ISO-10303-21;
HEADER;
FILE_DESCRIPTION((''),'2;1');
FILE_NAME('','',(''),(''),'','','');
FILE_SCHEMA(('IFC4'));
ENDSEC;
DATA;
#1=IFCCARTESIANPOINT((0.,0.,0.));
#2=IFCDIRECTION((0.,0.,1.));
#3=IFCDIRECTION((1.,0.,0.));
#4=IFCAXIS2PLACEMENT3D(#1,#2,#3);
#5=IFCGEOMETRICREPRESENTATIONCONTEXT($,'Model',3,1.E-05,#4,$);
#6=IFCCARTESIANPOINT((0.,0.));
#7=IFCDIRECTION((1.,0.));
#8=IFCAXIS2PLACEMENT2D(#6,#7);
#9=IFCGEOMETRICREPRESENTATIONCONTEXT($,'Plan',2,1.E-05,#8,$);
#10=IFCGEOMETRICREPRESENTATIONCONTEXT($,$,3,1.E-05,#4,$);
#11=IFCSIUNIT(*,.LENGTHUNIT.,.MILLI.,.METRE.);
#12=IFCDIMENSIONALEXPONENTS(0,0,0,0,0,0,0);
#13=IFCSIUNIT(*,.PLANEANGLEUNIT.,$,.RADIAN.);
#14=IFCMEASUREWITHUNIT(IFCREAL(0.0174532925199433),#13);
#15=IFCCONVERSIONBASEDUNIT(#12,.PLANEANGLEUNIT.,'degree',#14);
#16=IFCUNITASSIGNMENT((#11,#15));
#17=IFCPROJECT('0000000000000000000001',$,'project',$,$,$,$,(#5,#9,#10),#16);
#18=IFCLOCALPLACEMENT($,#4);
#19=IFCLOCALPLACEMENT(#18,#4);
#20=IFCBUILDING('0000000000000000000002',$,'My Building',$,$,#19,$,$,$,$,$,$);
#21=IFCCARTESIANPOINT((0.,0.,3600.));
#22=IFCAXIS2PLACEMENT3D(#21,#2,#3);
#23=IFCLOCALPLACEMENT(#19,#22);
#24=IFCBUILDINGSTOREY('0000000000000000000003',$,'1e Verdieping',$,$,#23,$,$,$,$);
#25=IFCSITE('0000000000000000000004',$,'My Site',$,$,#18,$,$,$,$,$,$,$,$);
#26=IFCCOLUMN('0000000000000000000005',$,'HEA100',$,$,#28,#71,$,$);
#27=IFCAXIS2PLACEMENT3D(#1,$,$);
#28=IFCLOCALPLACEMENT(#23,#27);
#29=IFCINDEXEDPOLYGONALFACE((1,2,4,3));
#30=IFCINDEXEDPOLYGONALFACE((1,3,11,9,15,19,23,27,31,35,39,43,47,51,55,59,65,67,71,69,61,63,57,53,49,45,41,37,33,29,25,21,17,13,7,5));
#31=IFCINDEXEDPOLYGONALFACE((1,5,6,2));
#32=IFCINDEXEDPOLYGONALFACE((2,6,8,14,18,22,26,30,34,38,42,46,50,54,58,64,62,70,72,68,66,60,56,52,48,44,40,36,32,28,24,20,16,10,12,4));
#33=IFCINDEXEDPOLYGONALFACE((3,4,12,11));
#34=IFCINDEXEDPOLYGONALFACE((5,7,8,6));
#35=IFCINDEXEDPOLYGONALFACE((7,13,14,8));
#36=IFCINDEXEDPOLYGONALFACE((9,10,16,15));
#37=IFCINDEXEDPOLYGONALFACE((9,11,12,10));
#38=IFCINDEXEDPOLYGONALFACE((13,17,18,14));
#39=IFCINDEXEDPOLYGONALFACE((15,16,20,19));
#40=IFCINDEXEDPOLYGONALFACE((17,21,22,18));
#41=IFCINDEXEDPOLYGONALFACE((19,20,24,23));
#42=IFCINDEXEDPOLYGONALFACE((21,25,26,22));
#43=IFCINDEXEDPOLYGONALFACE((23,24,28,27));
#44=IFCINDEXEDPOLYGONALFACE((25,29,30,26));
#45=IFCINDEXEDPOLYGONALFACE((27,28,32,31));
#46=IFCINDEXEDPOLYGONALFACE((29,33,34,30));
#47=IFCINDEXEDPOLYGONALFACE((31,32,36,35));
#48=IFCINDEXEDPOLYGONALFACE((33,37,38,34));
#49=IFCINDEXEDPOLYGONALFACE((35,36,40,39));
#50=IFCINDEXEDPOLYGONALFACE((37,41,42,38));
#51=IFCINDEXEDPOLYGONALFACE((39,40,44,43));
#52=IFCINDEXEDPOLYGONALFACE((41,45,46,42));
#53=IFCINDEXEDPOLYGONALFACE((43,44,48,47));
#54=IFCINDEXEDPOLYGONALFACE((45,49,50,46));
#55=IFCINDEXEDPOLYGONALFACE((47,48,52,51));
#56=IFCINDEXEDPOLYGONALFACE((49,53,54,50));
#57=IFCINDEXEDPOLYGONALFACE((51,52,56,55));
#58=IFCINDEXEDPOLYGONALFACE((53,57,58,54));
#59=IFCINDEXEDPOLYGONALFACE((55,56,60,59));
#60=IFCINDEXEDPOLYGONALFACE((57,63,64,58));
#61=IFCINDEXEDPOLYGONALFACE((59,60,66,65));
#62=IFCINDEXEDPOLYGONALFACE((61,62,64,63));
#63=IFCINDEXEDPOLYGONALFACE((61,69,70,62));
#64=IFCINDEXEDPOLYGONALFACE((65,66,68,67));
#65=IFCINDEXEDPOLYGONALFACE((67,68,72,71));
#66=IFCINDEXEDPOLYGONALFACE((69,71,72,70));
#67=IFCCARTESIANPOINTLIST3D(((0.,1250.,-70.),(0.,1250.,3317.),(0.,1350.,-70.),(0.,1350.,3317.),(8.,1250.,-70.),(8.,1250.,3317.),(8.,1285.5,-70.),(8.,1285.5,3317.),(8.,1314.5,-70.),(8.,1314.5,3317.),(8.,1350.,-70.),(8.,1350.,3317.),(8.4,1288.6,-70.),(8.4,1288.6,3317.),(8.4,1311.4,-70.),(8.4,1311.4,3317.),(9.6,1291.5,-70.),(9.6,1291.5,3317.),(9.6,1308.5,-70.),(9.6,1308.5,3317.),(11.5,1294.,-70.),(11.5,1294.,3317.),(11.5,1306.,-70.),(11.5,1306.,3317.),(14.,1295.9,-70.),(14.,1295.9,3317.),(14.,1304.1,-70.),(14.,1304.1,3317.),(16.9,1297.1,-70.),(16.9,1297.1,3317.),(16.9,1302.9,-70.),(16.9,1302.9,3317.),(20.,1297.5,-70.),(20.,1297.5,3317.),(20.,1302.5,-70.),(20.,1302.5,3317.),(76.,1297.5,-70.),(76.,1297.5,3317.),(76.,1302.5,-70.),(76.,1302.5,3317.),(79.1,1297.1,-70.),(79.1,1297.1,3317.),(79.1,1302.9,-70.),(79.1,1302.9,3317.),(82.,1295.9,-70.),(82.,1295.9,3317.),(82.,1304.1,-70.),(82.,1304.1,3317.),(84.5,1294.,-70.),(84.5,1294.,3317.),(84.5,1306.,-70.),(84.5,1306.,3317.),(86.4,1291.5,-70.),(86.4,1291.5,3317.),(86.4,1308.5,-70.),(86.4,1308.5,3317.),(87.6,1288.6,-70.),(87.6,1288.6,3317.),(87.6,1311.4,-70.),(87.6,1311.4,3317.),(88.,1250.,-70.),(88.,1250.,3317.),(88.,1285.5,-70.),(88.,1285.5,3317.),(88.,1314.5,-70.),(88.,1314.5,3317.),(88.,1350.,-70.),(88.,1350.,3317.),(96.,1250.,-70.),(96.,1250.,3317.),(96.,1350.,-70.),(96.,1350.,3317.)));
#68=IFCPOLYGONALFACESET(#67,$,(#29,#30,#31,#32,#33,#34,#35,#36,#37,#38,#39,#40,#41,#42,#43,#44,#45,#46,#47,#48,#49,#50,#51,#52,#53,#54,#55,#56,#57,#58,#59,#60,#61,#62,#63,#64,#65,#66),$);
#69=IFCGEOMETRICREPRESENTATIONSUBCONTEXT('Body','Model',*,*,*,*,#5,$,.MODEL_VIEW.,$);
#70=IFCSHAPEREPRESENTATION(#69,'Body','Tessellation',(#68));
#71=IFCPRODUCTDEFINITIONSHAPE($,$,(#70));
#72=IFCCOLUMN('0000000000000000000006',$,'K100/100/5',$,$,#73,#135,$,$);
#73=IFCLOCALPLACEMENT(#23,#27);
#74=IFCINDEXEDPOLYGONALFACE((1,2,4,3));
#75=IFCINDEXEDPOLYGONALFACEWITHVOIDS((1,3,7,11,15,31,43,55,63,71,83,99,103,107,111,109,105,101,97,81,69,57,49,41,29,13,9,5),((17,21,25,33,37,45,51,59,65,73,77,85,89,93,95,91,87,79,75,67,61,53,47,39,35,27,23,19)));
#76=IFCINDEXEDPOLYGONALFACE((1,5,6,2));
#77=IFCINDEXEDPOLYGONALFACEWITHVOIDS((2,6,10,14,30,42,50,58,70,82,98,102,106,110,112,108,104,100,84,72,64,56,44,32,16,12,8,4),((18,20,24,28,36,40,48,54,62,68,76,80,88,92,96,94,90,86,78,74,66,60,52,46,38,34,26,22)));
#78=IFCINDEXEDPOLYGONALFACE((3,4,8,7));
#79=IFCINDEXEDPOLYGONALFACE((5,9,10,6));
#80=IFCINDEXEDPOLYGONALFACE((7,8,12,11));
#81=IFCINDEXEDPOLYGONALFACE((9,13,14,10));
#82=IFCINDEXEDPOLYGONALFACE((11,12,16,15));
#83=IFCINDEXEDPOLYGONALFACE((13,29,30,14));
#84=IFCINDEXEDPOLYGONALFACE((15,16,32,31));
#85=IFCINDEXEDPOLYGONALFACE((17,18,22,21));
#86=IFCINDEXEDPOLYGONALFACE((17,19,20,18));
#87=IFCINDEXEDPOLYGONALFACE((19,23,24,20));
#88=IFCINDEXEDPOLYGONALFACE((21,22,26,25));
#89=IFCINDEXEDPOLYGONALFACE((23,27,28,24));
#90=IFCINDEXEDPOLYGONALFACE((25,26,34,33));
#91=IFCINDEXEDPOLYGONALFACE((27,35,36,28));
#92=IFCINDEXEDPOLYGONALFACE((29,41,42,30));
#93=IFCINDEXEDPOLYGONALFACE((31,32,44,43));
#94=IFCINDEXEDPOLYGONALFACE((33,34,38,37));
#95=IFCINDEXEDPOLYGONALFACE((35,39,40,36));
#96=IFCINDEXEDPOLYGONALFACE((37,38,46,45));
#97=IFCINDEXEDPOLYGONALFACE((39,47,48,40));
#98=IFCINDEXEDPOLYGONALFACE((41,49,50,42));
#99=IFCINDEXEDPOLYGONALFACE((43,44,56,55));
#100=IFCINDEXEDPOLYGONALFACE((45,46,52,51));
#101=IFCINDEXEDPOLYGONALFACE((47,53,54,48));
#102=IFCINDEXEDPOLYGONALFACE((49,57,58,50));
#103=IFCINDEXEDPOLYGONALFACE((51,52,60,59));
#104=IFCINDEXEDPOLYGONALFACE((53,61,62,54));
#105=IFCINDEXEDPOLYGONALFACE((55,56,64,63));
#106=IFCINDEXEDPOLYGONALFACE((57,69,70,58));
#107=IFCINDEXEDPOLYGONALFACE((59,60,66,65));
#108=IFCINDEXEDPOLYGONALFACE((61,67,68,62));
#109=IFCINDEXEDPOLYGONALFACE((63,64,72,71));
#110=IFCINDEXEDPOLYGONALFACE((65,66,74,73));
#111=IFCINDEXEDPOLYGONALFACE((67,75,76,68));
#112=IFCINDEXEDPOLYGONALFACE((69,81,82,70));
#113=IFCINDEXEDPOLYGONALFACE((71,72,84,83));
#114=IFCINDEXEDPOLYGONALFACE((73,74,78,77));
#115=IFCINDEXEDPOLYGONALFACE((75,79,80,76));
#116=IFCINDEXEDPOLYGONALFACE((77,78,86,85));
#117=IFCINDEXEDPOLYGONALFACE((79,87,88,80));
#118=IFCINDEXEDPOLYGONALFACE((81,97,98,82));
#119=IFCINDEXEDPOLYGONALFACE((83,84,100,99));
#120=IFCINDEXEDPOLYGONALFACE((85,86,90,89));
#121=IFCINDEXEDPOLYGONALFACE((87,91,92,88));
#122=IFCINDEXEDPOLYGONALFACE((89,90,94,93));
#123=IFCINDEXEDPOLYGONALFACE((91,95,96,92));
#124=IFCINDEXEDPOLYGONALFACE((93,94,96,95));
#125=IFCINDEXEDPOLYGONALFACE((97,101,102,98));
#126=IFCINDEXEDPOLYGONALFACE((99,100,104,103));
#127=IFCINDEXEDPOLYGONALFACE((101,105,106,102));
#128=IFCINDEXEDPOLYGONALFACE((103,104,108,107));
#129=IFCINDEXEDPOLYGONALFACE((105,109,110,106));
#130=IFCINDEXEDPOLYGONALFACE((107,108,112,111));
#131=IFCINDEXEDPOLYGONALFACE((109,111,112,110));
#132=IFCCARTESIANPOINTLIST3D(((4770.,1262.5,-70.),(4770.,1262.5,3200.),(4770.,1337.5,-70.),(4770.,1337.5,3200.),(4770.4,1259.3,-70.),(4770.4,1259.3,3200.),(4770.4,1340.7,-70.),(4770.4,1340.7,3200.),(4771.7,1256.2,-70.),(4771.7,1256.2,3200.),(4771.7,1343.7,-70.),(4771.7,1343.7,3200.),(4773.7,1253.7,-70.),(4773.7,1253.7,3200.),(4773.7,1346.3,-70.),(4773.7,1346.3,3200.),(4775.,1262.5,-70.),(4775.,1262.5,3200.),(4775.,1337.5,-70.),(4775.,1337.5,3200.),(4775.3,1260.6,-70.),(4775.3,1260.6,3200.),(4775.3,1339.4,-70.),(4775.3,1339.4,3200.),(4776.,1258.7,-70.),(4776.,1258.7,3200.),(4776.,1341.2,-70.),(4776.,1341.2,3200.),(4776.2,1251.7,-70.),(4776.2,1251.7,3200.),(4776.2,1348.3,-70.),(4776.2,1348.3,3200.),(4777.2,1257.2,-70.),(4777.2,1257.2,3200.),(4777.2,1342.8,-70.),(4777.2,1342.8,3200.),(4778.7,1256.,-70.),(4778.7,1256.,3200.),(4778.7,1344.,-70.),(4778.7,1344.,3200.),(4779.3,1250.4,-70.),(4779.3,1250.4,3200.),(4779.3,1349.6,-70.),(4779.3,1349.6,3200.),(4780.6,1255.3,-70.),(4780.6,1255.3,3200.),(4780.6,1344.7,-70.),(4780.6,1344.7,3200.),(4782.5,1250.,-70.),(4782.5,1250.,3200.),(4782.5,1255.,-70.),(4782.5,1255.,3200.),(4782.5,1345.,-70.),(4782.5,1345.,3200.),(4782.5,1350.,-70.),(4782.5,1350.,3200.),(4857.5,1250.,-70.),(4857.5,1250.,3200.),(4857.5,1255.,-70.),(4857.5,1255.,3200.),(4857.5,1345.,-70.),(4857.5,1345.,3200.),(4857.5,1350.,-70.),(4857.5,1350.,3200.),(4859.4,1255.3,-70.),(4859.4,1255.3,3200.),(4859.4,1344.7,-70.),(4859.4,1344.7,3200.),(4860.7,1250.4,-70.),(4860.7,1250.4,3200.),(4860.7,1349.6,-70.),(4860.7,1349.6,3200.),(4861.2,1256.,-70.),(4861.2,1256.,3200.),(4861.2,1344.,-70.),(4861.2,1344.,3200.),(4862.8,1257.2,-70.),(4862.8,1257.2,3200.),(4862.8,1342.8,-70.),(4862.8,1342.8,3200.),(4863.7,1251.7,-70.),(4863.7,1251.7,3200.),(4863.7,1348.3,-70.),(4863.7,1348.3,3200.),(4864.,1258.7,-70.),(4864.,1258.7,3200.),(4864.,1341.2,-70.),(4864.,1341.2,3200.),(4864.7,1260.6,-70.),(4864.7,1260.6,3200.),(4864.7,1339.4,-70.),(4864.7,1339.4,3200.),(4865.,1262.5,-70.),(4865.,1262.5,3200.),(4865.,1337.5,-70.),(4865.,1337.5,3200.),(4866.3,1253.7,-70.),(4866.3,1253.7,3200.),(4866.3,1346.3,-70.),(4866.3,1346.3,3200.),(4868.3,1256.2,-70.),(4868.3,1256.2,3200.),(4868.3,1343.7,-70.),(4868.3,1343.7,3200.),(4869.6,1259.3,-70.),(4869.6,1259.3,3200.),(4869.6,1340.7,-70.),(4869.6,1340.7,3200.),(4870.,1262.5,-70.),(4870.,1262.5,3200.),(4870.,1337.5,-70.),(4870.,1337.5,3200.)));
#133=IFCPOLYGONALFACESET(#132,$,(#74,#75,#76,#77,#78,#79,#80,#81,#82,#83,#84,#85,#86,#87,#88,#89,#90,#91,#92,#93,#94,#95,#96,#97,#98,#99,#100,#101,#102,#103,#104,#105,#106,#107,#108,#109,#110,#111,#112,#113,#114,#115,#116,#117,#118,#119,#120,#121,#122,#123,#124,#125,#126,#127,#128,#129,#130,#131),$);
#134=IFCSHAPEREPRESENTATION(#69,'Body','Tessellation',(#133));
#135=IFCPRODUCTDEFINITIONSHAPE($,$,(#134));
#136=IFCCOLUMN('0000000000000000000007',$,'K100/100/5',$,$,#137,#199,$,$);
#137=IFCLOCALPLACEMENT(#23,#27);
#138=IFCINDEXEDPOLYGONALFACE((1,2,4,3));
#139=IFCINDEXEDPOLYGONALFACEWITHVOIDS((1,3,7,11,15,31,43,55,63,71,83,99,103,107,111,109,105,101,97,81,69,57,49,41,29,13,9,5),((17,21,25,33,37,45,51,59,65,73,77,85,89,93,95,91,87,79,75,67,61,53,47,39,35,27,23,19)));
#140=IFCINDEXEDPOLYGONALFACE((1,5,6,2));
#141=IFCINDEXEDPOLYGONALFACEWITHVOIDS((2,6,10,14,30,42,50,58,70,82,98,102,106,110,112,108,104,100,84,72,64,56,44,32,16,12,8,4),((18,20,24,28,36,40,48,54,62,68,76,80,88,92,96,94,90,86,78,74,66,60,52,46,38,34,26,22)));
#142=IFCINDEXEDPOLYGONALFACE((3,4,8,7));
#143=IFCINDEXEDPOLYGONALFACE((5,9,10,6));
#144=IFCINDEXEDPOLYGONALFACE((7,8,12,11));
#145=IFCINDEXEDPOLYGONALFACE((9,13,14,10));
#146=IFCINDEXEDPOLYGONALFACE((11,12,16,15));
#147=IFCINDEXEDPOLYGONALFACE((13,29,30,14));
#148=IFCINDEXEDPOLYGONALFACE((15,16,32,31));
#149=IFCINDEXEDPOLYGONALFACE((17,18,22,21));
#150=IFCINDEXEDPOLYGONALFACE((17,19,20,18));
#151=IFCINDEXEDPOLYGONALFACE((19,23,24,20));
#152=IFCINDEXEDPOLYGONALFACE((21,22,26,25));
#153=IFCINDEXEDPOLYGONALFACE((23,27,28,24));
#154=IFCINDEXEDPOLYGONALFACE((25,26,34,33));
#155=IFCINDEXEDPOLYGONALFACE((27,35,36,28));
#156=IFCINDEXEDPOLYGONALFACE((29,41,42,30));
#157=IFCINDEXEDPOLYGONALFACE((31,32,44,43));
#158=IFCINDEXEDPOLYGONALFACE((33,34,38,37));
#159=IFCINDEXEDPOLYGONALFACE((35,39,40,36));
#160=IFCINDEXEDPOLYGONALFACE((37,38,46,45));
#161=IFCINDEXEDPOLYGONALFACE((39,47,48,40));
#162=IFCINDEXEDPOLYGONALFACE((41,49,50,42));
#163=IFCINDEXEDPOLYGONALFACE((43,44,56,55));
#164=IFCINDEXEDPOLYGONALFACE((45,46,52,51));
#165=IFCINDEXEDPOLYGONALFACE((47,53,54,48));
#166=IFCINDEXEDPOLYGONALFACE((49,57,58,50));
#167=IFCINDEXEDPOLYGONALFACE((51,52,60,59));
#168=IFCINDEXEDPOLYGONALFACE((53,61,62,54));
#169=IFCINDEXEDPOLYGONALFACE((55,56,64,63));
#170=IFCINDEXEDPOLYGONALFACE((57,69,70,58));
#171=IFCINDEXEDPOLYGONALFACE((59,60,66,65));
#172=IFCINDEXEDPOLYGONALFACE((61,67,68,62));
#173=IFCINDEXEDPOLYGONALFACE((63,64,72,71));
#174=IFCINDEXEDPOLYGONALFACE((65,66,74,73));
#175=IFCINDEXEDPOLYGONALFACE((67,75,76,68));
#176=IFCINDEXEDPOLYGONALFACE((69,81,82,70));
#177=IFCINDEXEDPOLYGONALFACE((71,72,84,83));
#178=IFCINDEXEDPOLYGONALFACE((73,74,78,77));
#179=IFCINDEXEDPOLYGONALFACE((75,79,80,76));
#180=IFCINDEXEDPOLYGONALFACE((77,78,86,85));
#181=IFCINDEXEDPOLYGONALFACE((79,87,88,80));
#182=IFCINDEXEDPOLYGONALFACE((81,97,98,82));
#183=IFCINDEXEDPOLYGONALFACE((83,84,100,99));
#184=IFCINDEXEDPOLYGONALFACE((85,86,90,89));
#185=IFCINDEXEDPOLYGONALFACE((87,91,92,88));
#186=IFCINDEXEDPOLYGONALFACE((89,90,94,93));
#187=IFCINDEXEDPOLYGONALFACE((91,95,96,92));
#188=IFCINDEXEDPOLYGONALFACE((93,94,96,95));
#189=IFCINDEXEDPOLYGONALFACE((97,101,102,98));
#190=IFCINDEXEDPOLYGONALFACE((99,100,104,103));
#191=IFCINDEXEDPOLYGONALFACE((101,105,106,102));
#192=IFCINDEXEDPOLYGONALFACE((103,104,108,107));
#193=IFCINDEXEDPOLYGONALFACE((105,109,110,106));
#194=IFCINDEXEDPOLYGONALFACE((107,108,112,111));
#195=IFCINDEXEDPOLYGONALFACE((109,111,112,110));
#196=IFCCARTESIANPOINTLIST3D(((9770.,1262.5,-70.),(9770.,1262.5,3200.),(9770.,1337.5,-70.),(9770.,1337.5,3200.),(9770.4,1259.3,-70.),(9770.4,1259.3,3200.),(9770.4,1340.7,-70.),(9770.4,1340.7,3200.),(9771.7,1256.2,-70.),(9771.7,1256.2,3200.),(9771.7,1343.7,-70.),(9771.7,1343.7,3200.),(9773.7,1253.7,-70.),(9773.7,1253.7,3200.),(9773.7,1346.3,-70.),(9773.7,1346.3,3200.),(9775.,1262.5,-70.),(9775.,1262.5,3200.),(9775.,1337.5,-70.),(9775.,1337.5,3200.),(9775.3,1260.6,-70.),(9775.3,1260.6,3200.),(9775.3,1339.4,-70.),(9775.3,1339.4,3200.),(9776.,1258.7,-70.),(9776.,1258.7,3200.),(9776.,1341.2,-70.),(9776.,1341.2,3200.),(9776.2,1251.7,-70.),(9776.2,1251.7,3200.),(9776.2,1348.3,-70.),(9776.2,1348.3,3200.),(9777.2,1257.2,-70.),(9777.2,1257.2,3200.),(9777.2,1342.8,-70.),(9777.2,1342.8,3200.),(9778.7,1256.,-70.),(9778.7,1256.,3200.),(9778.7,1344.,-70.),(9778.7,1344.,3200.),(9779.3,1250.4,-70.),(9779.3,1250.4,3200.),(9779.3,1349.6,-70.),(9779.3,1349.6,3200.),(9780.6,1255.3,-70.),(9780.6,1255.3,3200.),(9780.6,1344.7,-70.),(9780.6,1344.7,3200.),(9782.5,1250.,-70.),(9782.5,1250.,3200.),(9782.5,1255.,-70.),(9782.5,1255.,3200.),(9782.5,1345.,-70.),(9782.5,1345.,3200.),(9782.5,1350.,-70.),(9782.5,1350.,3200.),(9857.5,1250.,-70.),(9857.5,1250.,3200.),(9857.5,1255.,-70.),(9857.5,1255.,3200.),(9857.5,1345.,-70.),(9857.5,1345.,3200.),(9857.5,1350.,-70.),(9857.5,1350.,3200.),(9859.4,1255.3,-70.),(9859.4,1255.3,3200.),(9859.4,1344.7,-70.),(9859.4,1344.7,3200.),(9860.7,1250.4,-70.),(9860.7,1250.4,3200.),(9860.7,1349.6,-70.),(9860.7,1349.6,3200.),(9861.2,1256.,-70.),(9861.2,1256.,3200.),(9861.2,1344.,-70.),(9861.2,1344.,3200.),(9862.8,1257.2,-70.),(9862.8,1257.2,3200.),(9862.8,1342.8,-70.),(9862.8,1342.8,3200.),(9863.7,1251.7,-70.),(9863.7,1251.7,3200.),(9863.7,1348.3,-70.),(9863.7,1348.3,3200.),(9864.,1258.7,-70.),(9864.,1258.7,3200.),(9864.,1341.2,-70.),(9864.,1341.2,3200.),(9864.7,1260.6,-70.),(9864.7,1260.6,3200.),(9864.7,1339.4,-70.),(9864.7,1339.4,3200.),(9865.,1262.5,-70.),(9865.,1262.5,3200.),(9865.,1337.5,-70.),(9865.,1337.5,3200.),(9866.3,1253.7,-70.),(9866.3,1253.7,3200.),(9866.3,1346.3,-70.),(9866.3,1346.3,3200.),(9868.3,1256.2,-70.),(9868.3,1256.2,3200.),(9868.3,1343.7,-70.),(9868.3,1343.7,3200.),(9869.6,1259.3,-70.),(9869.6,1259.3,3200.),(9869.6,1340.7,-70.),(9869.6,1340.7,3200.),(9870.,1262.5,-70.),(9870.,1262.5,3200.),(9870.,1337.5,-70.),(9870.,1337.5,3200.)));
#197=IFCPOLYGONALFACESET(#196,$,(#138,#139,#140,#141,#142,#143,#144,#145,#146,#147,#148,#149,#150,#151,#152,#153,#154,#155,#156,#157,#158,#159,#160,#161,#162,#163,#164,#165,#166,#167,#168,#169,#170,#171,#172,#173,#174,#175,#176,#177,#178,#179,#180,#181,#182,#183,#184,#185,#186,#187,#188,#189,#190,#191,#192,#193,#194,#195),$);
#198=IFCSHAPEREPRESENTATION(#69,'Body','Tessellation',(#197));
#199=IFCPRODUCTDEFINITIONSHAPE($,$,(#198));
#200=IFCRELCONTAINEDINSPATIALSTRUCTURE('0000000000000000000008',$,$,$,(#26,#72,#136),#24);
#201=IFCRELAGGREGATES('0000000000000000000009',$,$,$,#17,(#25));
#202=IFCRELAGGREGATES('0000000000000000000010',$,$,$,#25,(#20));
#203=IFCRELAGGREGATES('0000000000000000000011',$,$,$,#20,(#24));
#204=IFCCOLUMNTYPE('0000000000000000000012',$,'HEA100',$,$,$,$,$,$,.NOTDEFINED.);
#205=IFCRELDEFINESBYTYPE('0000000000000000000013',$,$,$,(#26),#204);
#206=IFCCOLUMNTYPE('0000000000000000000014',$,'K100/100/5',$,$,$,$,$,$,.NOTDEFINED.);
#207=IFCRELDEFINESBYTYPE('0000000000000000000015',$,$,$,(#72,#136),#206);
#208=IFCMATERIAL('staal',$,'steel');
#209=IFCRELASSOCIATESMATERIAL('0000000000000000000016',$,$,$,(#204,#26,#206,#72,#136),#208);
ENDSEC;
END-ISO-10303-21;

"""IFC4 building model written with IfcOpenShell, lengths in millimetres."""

from ifc_helpers import new_model, entity, si_unit, converted_unit, frame, origin_with_axes, origin_2d_with_axis, place, context, subcontext, project, spatial, hollow_rectangle, i_section, extrude, material, material_profile, profile_set, profile_usage, type_object, element, save


model = new_model("IFC4")

# Units and contexts
model_context = context("Model", 3, precision=1e-05, world=origin_with_axes())
plan_context = context("Plan", 2, precision=1e-05, world=origin_2d_with_axis())
context_of_model = context(None, 3, precision=1e-05, world=origin_with_axes())
body_context = subcontext(model_context, "Body", "Model", "MODEL_VIEW")
ifc_project = project(units=[si_unit("LENGTHUNIT", "METRE", prefix="MILLI"), converted_unit("PLANEANGLEUNIT", "degree", entity("IfcReal", 0.0174532925199433), si_unit("PLANEANGLEUNIT", "RADIAN"), dimensions=[0, 0, 0, 0, 0, 0, 0])], contexts=[model_context, plan_context, context_of_model])

# Site, building, storey
site_placement = place(None, origin_with_axes())
site = spatial("IfcSite", under=ifc_project, at=site_placement, Name="My Site")
building_placement = place(site_placement, origin_with_axes())
building = spatial("IfcBuilding", under=site, at=building_placement, Name="My Building")
storey_placement = place(building_placement, frame((0.0, 0.0, 3600.0), z_axis=(0.0, 0.0, 1.0), x_axis=(1.0, 0.0, 0.0)))
storey = spatial("IfcBuildingStorey", under=building, at=storey_placement, Name="1e Verdieping")

# Columns
ifc_material_1 = material(Name="staal", Category="steel")
ifc_material_profile_1 = material_profile(ifc_material_1, i_section(OverallWidth=100.0, OverallDepth=96.0, WebThickness=5.0, FlangeThickness=8.0, FilletRadius=12.0))
ifc_profile_set_1 = profile_set([ifc_material_profile_1], Name="HEA100")
column_type_1 = type_object("IfcColumnType", Name="HEA100", PredefinedType="NOTDEFINED", material=ifc_profile_set_1)
ifc_profile_usage_1 = profile_usage(ifc_profile_set_1)
column_1_placement = place(storey_placement, frame((48.0, 1300.0, -70.0), z_axis=(0.0, 0.0, 1.0), x_axis=(0.0, 1.0, 0.0)))
element("IfcColumn", 1, at=column_1_placement, inside=storey, type_object=column_type_1, material=ifc_profile_usage_1, Name="HEA100", context=body_context, shape_type="SweptSolid", body=[
    extrude(i_section(OverallWidth=100.0, OverallDepth=96.0, WebThickness=5.0, FlangeThickness=8.0, FilletRadius=12.0), origin_with_axes(), (0.0, 0.0, 1.0), 3387.0),
])
ifc_material_profile_2 = material_profile(ifc_material_1, hollow_rectangle(XDim=100.0, YDim=100.0, WallThickness=5.0, InnerFilletRadius=7.5, OuterFilletRadius=12.5))
ifc_profile_set_2 = profile_set([ifc_material_profile_2], Name="K100/100/5")
ifc_profile_usage_2 = profile_usage(ifc_profile_set_2, cardinal=5)
column_type_2 = type_object("IfcColumnType", Name="K100/100/5", PredefinedType="NOTDEFINED", material=ifc_profile_set_2)
column_2_placement = place(storey_placement, frame((4820.0, 1300.0, -70.0), z_axis=(0.0, 0.0, 1.0), x_axis=(1.0, 0.0, 0.0)))
element("IfcColumn", 2, at=column_2_placement, inside=storey, type_object=column_type_2, material=ifc_profile_usage_2, Name="K100/100/5", context=body_context, shape_type="SweptSolid", body=[
    extrude(hollow_rectangle(XDim=100.0, YDim=100.0, WallThickness=5.0, InnerFilletRadius=7.5, OuterFilletRadius=12.5), origin_with_axes(), (0.0, 0.0, 1.0), 3270.0),
])
ifc_profile_usage_3 = profile_usage(ifc_profile_set_2, cardinal=5)
column_3_placement = place(storey_placement, frame((9820.0, 1300.0, -70.0), z_axis=(0.0, 0.0, 1.0), x_axis=(1.0, 0.0, 0.0)))
element("IfcColumn", 3, at=column_3_placement, inside=storey, type_object=column_type_2, material=ifc_profile_usage_3, Name="K100/100/5", context=body_context, shape_type="SweptSolid", body=[
    extrude(hollow_rectangle(XDim=100.0, YDim=100.0, WallThickness=5.0, InnerFilletRadius=7.5, OuterFilletRadius=12.5), origin_with_axes(), (0.0, 0.0, 1.0), 3270.0),
])

save(model, "model.ifc")
